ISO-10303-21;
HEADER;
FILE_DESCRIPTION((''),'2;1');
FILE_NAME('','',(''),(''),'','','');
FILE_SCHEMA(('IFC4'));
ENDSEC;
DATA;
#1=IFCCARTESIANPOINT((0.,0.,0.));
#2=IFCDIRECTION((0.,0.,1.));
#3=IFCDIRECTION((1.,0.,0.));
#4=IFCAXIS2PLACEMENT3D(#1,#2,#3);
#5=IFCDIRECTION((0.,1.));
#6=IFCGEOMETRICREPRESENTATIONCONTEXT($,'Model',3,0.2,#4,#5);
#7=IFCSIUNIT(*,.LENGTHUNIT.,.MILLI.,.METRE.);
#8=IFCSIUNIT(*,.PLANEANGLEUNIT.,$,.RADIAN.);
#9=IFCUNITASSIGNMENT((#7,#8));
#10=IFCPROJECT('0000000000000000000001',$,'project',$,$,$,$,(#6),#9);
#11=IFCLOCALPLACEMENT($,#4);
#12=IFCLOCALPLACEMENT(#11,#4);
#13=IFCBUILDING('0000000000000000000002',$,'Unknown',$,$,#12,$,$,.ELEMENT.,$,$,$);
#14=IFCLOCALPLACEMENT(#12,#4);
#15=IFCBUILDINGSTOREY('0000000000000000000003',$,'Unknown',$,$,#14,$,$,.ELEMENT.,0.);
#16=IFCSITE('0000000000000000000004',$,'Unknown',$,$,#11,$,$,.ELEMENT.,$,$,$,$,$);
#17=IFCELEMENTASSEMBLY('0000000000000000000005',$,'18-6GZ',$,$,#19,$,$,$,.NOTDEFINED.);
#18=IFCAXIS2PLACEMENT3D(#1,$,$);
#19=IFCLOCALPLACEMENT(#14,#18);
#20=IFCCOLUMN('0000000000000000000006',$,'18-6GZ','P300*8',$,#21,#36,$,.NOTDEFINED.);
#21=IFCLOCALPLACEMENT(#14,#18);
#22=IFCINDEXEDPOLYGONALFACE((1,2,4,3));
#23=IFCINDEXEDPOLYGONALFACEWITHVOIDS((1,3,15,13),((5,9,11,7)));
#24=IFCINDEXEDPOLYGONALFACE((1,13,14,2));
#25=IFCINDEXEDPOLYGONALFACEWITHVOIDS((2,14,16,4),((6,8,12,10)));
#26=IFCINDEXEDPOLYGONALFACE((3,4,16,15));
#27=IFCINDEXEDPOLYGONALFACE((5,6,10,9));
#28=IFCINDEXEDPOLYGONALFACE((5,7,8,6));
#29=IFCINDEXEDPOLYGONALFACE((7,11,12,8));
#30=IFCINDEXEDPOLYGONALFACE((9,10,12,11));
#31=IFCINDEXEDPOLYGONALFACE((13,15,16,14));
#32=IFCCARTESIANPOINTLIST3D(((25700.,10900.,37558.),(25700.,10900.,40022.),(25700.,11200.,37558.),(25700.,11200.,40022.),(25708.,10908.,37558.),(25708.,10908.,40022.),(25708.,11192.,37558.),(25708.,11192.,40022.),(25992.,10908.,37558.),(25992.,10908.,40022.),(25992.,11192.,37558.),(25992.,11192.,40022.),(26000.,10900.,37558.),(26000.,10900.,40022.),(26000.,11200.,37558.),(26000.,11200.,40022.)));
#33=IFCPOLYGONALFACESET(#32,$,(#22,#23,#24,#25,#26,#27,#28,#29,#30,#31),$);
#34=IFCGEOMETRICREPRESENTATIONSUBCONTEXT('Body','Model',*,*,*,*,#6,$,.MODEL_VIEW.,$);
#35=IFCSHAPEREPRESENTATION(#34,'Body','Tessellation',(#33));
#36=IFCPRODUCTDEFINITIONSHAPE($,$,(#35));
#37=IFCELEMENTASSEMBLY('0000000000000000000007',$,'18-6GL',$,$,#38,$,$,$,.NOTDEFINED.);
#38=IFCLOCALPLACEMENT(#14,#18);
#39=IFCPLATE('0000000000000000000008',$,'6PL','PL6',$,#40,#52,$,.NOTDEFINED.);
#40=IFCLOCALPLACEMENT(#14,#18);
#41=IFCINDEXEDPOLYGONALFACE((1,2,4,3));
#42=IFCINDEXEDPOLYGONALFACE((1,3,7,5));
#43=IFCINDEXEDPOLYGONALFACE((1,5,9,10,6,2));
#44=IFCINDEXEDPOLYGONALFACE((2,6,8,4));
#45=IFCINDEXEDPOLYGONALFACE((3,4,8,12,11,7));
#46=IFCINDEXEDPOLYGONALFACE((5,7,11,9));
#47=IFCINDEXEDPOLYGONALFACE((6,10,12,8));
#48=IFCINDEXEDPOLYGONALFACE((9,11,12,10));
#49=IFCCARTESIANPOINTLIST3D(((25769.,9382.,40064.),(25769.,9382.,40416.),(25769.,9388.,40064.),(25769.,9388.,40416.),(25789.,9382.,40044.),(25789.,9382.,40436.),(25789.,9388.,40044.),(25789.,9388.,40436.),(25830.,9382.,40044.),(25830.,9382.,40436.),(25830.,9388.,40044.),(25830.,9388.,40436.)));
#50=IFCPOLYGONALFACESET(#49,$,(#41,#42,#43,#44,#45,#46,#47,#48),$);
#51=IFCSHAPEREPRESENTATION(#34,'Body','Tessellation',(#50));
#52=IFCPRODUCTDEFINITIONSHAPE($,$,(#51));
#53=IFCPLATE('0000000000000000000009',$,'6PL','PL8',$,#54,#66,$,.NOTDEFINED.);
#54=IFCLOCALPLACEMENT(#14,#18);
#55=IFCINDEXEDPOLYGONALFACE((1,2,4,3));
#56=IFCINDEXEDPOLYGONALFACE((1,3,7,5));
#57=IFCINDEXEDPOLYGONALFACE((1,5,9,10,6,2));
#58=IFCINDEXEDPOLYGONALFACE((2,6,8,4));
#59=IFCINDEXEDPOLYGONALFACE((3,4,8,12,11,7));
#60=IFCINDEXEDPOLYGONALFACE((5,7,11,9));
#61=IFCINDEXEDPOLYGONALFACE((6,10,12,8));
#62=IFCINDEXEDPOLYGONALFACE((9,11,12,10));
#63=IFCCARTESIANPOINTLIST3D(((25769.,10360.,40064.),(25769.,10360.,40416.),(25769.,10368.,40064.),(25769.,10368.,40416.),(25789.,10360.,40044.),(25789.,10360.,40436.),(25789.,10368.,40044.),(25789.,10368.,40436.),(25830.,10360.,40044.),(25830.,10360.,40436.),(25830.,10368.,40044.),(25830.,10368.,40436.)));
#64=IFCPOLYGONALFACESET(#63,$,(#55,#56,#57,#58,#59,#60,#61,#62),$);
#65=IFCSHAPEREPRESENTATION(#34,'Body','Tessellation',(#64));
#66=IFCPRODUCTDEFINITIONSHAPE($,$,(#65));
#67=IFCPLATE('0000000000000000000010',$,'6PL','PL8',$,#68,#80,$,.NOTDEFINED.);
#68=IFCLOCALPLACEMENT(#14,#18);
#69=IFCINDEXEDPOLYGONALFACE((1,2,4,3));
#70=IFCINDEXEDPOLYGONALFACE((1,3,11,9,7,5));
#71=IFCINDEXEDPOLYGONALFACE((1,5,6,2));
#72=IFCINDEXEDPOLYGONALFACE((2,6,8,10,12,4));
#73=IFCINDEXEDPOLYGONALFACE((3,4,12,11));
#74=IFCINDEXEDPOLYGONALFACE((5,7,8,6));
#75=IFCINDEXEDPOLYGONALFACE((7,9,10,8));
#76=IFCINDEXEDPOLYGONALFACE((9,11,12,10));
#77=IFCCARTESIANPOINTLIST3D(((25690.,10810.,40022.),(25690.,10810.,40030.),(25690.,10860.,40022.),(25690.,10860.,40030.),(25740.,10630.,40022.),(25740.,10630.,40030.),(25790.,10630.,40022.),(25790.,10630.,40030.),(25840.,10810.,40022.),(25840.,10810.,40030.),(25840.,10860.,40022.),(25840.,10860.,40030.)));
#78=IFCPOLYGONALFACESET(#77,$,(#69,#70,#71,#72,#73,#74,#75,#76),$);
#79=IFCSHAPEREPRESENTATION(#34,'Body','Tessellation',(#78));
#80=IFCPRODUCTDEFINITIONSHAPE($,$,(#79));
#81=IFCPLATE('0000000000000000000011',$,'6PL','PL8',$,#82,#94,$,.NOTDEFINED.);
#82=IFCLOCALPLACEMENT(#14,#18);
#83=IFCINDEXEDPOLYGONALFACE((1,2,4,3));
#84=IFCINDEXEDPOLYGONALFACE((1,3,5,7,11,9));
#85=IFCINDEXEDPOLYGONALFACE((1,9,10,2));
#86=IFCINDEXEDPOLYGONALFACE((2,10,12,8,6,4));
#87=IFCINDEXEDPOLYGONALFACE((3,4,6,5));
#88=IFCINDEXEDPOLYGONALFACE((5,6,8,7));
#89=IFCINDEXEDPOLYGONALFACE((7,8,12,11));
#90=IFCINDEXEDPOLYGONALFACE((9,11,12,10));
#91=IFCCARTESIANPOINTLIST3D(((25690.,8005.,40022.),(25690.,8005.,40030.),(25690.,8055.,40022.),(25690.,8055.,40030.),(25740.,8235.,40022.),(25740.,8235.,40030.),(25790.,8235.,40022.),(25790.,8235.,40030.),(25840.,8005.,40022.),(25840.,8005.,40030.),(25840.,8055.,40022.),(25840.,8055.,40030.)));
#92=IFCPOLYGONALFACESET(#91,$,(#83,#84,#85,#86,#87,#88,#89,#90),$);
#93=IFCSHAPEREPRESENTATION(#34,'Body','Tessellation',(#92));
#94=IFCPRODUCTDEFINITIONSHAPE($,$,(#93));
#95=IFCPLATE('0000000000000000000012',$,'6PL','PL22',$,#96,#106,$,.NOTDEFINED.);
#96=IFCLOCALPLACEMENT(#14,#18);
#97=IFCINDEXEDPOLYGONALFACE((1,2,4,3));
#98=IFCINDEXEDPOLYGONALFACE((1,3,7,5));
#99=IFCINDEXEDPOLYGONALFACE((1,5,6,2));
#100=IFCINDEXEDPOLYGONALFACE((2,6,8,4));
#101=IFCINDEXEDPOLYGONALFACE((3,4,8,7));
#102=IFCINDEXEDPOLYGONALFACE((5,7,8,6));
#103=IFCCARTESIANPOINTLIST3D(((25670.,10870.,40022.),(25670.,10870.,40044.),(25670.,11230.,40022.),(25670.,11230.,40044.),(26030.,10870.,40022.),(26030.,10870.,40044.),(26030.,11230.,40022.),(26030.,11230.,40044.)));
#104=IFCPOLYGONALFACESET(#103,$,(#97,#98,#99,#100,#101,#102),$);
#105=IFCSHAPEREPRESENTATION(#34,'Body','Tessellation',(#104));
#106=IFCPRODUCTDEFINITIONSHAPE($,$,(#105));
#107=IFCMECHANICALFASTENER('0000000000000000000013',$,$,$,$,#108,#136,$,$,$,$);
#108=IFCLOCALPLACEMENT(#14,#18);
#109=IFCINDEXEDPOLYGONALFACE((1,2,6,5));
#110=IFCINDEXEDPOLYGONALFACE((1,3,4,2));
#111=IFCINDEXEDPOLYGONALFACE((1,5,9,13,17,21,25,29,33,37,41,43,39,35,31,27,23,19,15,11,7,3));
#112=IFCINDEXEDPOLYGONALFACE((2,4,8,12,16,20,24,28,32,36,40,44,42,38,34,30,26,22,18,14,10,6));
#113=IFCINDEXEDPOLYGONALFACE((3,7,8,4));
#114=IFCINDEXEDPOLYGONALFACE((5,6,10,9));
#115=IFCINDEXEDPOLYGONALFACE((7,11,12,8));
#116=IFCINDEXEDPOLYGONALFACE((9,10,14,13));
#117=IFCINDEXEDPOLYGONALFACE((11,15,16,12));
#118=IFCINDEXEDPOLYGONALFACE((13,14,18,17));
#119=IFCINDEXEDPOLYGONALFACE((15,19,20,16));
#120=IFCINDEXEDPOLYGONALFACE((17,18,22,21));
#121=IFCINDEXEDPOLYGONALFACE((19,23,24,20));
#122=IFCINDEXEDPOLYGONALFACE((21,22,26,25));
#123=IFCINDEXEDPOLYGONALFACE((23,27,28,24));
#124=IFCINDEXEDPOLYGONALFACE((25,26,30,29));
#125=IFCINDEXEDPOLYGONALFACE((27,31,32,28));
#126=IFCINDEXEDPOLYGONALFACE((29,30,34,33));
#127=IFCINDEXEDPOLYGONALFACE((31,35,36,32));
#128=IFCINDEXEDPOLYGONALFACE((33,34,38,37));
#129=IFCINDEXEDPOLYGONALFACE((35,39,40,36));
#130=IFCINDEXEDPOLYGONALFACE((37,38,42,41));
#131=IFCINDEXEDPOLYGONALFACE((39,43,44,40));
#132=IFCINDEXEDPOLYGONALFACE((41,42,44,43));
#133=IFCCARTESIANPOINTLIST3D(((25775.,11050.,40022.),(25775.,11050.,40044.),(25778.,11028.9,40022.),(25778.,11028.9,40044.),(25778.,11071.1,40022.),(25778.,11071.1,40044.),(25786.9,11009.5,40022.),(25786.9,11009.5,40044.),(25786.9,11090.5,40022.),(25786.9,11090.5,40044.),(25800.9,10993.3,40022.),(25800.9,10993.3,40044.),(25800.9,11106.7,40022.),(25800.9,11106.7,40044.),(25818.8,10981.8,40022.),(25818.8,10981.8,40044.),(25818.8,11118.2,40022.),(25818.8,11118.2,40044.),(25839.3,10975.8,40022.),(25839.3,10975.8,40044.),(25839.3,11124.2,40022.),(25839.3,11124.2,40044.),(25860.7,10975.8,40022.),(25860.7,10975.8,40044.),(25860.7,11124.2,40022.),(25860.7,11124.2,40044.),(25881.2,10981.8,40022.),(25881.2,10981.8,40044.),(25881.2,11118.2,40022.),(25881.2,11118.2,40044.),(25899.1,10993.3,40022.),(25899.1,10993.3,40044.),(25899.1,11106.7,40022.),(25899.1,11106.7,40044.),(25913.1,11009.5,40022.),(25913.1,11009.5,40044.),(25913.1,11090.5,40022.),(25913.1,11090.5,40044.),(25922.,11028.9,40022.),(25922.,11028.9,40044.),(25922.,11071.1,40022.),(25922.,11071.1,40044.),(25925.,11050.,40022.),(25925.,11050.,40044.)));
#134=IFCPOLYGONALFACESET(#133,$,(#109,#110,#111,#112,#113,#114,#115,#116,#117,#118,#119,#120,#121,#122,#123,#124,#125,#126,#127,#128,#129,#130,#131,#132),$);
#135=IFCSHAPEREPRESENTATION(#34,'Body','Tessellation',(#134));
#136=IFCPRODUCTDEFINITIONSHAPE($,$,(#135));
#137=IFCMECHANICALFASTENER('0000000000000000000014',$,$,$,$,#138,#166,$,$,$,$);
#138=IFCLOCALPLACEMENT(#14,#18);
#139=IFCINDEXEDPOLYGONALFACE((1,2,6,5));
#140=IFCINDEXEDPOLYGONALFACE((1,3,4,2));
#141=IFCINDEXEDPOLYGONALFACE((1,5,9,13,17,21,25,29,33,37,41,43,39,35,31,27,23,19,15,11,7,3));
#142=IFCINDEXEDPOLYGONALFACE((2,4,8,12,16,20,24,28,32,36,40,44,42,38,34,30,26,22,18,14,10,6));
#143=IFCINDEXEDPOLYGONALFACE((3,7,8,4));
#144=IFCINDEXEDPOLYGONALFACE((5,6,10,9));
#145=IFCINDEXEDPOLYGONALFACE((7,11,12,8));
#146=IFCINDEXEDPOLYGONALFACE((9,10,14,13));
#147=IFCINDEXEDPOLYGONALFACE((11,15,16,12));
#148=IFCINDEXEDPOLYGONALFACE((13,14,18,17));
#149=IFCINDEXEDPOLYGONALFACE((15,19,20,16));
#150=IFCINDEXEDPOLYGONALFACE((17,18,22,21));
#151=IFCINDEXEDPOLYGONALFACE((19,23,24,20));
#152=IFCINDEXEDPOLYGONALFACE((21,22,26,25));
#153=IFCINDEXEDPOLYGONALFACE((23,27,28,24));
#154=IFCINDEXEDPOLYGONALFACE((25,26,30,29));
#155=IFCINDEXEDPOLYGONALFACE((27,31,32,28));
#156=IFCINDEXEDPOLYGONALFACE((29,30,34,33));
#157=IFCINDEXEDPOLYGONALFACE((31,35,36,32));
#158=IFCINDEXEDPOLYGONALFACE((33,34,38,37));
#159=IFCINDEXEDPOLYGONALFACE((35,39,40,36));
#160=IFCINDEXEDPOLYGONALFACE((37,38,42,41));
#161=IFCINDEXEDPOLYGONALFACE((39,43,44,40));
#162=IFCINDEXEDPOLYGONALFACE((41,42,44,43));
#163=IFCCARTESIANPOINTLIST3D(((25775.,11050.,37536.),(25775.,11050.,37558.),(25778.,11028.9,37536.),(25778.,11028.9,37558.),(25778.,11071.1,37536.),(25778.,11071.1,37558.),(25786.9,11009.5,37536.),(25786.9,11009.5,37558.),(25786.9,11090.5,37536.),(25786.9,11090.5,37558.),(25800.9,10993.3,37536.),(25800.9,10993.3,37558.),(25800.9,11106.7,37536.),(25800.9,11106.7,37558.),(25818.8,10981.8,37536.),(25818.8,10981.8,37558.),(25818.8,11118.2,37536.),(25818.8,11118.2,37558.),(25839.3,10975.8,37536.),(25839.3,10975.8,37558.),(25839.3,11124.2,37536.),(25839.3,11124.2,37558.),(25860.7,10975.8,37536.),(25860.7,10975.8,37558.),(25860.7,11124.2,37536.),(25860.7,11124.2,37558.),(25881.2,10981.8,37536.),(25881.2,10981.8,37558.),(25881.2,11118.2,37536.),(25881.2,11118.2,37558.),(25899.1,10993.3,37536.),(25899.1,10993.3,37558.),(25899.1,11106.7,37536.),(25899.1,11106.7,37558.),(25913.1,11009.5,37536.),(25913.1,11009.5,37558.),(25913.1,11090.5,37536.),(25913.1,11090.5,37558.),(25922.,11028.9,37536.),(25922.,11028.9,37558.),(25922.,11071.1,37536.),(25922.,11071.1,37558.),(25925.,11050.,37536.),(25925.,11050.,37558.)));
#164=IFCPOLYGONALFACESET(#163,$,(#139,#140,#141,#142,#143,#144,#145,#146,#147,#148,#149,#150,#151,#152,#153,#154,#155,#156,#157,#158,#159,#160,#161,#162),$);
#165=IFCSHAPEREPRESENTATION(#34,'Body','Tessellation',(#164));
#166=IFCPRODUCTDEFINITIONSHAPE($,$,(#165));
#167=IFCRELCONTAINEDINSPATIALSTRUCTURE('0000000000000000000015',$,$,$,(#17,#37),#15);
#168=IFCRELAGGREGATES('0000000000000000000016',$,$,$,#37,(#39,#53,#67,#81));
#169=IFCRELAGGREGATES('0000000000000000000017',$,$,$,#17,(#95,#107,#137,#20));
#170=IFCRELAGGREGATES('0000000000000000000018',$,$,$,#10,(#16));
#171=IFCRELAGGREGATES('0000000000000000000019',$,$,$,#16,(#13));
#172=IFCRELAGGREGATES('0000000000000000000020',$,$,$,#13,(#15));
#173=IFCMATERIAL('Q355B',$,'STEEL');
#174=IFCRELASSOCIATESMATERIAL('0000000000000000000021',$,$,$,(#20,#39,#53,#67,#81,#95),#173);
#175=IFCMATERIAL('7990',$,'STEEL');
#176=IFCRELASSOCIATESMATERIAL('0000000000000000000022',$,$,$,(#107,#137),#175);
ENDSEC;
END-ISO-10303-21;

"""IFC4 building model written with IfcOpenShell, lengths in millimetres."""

from ifc_helpers import new_model, si_unit, direction, frame, origin_with_axes, place, context, subcontext, project, spatial, line, arc, indexed_curve, outline, extrude, source, transform, mapped, material, element, aggregate, save


model = new_model("IFC4")

# Units and contexts
model_context = context("Model", 3, precision=0.2, world=origin_with_axes(), true_north=direction((0.0, 1.0)))
body_context = subcontext(model_context, "Body", "Model", "MODEL_VIEW")
ifc_project = project(units=[si_unit("LENGTHUNIT", "METRE", prefix="MILLI"), si_unit("PLANEANGLEUNIT", "RADIAN")], contexts=[model_context])

# Site, building, storey
site_placement = place(None, origin_with_axes())
site = spatial("IfcSite", under=ifc_project, at=site_placement, Name="Unknown", CompositionType="ELEMENT")
building_placement = place(site_placement, origin_with_axes())
building = spatial("IfcBuilding", under=site, at=building_placement, Name="Unknown", CompositionType="ELEMENT")
storey_placement = place(building_placement, origin_with_axes())
storey = spatial("IfcBuildingStorey", under=building, at=storey_placement, Name="Unknown", CompositionType="ELEMENT", Elevation=0.0)

# Element assembly, column
assembly_1_placement = place(storey_placement, frame((25850.0, 11050.0, 35950.0), z_axis=(-1.0, 0.0, 0.0), x_axis=(0.0, 0.0, 1.0)))
assembly_1 = element("IfcElementAssembly", 1, at=assembly_1_placement, inside=storey, Name="18-6GZ", PredefinedType="NOTDEFINED")
ifc_material_1 = material(Name="Q355B", Category="STEEL")
column_placement = place(assembly_1_placement, frame((1608.0, 0.0, 0.0), z_axis=(0.0, 0.0, 1.0), x_axis=(1.0, 0.0, 0.0)))
column = element("IfcColumn", 2, at=column_placement, material=ifc_material_1, Name="18-6GZ", Description="P300*8", PredefinedType="NOTDEFINED", context=body_context, shape_type="SolidModel", body=[
    extrude(outline(indexed_curve([(-150.0, -150.0), (150.0, -150.0), (150.0, 150.0), (-150.0, 150.0)], segments=[line(1, 2, 3, 4, 1)]), holes=[indexed_curve([(-142.0, -142.0), (-142.0, 142.0), (142.0, 142.0), (142.0, -142.0)], segments=[line(1, 2, 3, 4, 1)])]), frame((0.0, 0.0, 0.0), z_axis=(-1.0, 0.0, 0.0), x_axis=(0.0, 0.0, 1.0)), (0.0, 0.0, -1.0), 2464.0),
])

# Element assembly, plates
assembly_2_placement = place(storey_placement, frame((25765.0, 10900.0, 40240.0), z_axis=(-1.0, 0.0, 0.0), x_axis=(0.0, -1.0, 0.0)))
assembly_2 = element("IfcElementAssembly", 3, at=assembly_2_placement, inside=storey, Name="18-6GL", PredefinedType="NOTDEFINED")
plate_1_placement = place(assembly_2_placement, frame((1515.0, -196.0, -65.0), z_axis=(-1.0, 0.0, 0.0), x_axis=(0.0, 0.0, 1.0)))
plate_1 = element("IfcPlate", 4, at=plate_1_placement, material=ifc_material_1, Name="6PL", Description="PL6", PredefinedType="NOTDEFINED", context=body_context, shape_type="SolidModel", body=[
    extrude(outline(indexed_curve([(0.0, 0.0), (41.0, 0.0), (61.0, 20.0), (61.0, 372.0), (41.0, 392.0), (0.0, 392.0)], segments=[line(1, 2, 3, 4, 5, 6, 1)])), frame((0.0, 0.0, 3.0), z_axis=(0.0, 0.0, 1.0), x_axis=(1.0, 0.0, 0.0)), (0.0, 0.0, -1.0), 6.0),
])
plate_2_placement = place(assembly_2_placement, frame((536.0, -196.0, -65.0), z_axis=(-1.0, 0.0, 0.0), x_axis=(0.0, 0.0, 1.0)))
plate_2 = element("IfcPlate", 5, at=plate_2_placement, material=ifc_material_1, Name="6PL", Description="PL8", PredefinedType="NOTDEFINED", context=body_context, shape_type="SolidModel", body=[
    extrude(outline(indexed_curve([(0.0, 0.0), (41.0, 0.0), (61.0, 20.0), (61.0, 372.0), (41.0, 392.0), (0.0, 392.0)], segments=[line(1, 2, 3, 4, 5, 6, 1)])), frame((0.0, 0.0, 4.0), z_axis=(0.0, 0.0, 1.0), x_axis=(1.0, 0.0, 0.0)), (0.0, 0.0, -1.0), 8.0),
])
plate_3_placement = place(assembly_2_placement, frame((90.0, -214.0, -75.0), z_axis=(0.0, 1.0, 0.0), x_axis=(-1.0, 0.0, 0.0)))
plate_3 = element("IfcPlate", 6, at=plate_3_placement, material=ifc_material_1, Name="6PL", Description="PL8", PredefinedType="NOTDEFINED", context=body_context, shape_type="SolidModel", body=[
    extrude(outline(indexed_curve([(0.0, 0.0), (50.0, 0.0), (50.0, 150.0), (0.0, 150.0), (-180.0, 100.0), (-180.0, 50.0)], segments=[line(1, 2, 3, 4, 5, 6, 1)])), frame((0.0, 0.0, 4.0), z_axis=(0.0, 0.0, 1.0), x_axis=(1.0, 0.0, 0.0)), (0.0, 0.0, -1.0), 8.0),
])
plate_4_placement = place(assembly_2_placement, frame((2845.0, -214.0, -75.0), z_axis=(0.0, -1.0, 0.0), x_axis=(1.0, 0.0, 0.0)))
plate_4 = element("IfcPlate", 7, at=plate_4_placement, material=ifc_material_1, Name="6PL", Description="PL8", PredefinedType="NOTDEFINED", context=body_context, shape_type="SolidModel", body=[
    extrude(outline(indexed_curve([(0.0, 0.0), (50.0, 0.0), (50.0, 150.0), (0.0, 150.0), (-180.0, 100.0), (-180.0, 50.0)], segments=[line(1, 2, 3, 4, 5, 6, 1)])), frame((0.0, 0.0, 4.0), z_axis=(0.0, 0.0, 1.0), x_axis=(1.0, 0.0, 0.0)), (0.0, 0.0, -1.0), 8.0),
])
aggregate(assembly_2, [plate_1, plate_2, plate_3, plate_4])

# Plate
plate_5_placement = place(assembly_1_placement, frame((4083.0, -180.0, -180.0), z_axis=(-1.0, 0.0, 0.0), x_axis=(0.0, 0.0, 1.0)))
plate_5 = element("IfcPlate", 8, at=plate_5_placement, material=ifc_material_1, Name="6PL", Description="PL22", PredefinedType="NOTDEFINED", context=body_context, shape_type="SolidModel", body=[
    extrude(outline(indexed_curve([(0.0, 0.0), (360.0, 0.0), (360.0, 360.0), (0.0, 360.0)], segments=[line(1, 2, 3, 4, 1)])), frame((0.0, 0.0, 11.0), z_axis=(0.0, 0.0, 1.0), x_axis=(1.0, 0.0, 0.0)), (0.0, 0.0, -1.0), 22.0),
])

# Mechanical fasteners
ifc_material_2 = material(Name="7990", Category="STEEL")
shared_shape_1 = source(origin_with_axes(), body_context, "Body", "SweptSolid", [
    extrude(outline(indexed_curve([(75.0, 0.0), (0.0, 75.0), (-75.0, 0.0), (0.0, -75.0)], segments=[arc(1, 2, 3), arc(3, 4, 1)])), frame((0.0, 0.0, 0.0), z_axis=(0.0, 0.0, -1.0), x_axis=(0.0, 1.0, 0.0)), (0.0, 0.0, 1.0), 22.0),
])
placement_1 = place(assembly_1_placement, frame((4072.0, 0.0, 0.0), z_axis=(-1.0, 0.0, 0.0), x_axis=(0.0, 1.0, 0.0)))
mechanical_fastener_1 = element("IfcMechanicalFastener", 9, at=placement_1, material=ifc_material_2, context=body_context, shape_type="MappedRepresentation", body=[
    mapped(shared_shape_1, transform((0.0, 0.0, 0.0))),
])
placement_2 = place(assembly_1_placement, frame((1608.0, 0.0, 0.0), z_axis=(1.0, 0.0, 0.0), x_axis=(0.0, 1.0, 0.0)))
mechanical_fastener_2 = element("IfcMechanicalFastener", 10, at=placement_2, material=ifc_material_2, context=body_context, shape_type="MappedRepresentation", body=[
    mapped(shared_shape_1, transform((0.0, 0.0, 0.0))),
])
aggregate(assembly_1, [plate_5, mechanical_fastener_1, mechanical_fastener_2, column])

save(model, "model.ifc")
